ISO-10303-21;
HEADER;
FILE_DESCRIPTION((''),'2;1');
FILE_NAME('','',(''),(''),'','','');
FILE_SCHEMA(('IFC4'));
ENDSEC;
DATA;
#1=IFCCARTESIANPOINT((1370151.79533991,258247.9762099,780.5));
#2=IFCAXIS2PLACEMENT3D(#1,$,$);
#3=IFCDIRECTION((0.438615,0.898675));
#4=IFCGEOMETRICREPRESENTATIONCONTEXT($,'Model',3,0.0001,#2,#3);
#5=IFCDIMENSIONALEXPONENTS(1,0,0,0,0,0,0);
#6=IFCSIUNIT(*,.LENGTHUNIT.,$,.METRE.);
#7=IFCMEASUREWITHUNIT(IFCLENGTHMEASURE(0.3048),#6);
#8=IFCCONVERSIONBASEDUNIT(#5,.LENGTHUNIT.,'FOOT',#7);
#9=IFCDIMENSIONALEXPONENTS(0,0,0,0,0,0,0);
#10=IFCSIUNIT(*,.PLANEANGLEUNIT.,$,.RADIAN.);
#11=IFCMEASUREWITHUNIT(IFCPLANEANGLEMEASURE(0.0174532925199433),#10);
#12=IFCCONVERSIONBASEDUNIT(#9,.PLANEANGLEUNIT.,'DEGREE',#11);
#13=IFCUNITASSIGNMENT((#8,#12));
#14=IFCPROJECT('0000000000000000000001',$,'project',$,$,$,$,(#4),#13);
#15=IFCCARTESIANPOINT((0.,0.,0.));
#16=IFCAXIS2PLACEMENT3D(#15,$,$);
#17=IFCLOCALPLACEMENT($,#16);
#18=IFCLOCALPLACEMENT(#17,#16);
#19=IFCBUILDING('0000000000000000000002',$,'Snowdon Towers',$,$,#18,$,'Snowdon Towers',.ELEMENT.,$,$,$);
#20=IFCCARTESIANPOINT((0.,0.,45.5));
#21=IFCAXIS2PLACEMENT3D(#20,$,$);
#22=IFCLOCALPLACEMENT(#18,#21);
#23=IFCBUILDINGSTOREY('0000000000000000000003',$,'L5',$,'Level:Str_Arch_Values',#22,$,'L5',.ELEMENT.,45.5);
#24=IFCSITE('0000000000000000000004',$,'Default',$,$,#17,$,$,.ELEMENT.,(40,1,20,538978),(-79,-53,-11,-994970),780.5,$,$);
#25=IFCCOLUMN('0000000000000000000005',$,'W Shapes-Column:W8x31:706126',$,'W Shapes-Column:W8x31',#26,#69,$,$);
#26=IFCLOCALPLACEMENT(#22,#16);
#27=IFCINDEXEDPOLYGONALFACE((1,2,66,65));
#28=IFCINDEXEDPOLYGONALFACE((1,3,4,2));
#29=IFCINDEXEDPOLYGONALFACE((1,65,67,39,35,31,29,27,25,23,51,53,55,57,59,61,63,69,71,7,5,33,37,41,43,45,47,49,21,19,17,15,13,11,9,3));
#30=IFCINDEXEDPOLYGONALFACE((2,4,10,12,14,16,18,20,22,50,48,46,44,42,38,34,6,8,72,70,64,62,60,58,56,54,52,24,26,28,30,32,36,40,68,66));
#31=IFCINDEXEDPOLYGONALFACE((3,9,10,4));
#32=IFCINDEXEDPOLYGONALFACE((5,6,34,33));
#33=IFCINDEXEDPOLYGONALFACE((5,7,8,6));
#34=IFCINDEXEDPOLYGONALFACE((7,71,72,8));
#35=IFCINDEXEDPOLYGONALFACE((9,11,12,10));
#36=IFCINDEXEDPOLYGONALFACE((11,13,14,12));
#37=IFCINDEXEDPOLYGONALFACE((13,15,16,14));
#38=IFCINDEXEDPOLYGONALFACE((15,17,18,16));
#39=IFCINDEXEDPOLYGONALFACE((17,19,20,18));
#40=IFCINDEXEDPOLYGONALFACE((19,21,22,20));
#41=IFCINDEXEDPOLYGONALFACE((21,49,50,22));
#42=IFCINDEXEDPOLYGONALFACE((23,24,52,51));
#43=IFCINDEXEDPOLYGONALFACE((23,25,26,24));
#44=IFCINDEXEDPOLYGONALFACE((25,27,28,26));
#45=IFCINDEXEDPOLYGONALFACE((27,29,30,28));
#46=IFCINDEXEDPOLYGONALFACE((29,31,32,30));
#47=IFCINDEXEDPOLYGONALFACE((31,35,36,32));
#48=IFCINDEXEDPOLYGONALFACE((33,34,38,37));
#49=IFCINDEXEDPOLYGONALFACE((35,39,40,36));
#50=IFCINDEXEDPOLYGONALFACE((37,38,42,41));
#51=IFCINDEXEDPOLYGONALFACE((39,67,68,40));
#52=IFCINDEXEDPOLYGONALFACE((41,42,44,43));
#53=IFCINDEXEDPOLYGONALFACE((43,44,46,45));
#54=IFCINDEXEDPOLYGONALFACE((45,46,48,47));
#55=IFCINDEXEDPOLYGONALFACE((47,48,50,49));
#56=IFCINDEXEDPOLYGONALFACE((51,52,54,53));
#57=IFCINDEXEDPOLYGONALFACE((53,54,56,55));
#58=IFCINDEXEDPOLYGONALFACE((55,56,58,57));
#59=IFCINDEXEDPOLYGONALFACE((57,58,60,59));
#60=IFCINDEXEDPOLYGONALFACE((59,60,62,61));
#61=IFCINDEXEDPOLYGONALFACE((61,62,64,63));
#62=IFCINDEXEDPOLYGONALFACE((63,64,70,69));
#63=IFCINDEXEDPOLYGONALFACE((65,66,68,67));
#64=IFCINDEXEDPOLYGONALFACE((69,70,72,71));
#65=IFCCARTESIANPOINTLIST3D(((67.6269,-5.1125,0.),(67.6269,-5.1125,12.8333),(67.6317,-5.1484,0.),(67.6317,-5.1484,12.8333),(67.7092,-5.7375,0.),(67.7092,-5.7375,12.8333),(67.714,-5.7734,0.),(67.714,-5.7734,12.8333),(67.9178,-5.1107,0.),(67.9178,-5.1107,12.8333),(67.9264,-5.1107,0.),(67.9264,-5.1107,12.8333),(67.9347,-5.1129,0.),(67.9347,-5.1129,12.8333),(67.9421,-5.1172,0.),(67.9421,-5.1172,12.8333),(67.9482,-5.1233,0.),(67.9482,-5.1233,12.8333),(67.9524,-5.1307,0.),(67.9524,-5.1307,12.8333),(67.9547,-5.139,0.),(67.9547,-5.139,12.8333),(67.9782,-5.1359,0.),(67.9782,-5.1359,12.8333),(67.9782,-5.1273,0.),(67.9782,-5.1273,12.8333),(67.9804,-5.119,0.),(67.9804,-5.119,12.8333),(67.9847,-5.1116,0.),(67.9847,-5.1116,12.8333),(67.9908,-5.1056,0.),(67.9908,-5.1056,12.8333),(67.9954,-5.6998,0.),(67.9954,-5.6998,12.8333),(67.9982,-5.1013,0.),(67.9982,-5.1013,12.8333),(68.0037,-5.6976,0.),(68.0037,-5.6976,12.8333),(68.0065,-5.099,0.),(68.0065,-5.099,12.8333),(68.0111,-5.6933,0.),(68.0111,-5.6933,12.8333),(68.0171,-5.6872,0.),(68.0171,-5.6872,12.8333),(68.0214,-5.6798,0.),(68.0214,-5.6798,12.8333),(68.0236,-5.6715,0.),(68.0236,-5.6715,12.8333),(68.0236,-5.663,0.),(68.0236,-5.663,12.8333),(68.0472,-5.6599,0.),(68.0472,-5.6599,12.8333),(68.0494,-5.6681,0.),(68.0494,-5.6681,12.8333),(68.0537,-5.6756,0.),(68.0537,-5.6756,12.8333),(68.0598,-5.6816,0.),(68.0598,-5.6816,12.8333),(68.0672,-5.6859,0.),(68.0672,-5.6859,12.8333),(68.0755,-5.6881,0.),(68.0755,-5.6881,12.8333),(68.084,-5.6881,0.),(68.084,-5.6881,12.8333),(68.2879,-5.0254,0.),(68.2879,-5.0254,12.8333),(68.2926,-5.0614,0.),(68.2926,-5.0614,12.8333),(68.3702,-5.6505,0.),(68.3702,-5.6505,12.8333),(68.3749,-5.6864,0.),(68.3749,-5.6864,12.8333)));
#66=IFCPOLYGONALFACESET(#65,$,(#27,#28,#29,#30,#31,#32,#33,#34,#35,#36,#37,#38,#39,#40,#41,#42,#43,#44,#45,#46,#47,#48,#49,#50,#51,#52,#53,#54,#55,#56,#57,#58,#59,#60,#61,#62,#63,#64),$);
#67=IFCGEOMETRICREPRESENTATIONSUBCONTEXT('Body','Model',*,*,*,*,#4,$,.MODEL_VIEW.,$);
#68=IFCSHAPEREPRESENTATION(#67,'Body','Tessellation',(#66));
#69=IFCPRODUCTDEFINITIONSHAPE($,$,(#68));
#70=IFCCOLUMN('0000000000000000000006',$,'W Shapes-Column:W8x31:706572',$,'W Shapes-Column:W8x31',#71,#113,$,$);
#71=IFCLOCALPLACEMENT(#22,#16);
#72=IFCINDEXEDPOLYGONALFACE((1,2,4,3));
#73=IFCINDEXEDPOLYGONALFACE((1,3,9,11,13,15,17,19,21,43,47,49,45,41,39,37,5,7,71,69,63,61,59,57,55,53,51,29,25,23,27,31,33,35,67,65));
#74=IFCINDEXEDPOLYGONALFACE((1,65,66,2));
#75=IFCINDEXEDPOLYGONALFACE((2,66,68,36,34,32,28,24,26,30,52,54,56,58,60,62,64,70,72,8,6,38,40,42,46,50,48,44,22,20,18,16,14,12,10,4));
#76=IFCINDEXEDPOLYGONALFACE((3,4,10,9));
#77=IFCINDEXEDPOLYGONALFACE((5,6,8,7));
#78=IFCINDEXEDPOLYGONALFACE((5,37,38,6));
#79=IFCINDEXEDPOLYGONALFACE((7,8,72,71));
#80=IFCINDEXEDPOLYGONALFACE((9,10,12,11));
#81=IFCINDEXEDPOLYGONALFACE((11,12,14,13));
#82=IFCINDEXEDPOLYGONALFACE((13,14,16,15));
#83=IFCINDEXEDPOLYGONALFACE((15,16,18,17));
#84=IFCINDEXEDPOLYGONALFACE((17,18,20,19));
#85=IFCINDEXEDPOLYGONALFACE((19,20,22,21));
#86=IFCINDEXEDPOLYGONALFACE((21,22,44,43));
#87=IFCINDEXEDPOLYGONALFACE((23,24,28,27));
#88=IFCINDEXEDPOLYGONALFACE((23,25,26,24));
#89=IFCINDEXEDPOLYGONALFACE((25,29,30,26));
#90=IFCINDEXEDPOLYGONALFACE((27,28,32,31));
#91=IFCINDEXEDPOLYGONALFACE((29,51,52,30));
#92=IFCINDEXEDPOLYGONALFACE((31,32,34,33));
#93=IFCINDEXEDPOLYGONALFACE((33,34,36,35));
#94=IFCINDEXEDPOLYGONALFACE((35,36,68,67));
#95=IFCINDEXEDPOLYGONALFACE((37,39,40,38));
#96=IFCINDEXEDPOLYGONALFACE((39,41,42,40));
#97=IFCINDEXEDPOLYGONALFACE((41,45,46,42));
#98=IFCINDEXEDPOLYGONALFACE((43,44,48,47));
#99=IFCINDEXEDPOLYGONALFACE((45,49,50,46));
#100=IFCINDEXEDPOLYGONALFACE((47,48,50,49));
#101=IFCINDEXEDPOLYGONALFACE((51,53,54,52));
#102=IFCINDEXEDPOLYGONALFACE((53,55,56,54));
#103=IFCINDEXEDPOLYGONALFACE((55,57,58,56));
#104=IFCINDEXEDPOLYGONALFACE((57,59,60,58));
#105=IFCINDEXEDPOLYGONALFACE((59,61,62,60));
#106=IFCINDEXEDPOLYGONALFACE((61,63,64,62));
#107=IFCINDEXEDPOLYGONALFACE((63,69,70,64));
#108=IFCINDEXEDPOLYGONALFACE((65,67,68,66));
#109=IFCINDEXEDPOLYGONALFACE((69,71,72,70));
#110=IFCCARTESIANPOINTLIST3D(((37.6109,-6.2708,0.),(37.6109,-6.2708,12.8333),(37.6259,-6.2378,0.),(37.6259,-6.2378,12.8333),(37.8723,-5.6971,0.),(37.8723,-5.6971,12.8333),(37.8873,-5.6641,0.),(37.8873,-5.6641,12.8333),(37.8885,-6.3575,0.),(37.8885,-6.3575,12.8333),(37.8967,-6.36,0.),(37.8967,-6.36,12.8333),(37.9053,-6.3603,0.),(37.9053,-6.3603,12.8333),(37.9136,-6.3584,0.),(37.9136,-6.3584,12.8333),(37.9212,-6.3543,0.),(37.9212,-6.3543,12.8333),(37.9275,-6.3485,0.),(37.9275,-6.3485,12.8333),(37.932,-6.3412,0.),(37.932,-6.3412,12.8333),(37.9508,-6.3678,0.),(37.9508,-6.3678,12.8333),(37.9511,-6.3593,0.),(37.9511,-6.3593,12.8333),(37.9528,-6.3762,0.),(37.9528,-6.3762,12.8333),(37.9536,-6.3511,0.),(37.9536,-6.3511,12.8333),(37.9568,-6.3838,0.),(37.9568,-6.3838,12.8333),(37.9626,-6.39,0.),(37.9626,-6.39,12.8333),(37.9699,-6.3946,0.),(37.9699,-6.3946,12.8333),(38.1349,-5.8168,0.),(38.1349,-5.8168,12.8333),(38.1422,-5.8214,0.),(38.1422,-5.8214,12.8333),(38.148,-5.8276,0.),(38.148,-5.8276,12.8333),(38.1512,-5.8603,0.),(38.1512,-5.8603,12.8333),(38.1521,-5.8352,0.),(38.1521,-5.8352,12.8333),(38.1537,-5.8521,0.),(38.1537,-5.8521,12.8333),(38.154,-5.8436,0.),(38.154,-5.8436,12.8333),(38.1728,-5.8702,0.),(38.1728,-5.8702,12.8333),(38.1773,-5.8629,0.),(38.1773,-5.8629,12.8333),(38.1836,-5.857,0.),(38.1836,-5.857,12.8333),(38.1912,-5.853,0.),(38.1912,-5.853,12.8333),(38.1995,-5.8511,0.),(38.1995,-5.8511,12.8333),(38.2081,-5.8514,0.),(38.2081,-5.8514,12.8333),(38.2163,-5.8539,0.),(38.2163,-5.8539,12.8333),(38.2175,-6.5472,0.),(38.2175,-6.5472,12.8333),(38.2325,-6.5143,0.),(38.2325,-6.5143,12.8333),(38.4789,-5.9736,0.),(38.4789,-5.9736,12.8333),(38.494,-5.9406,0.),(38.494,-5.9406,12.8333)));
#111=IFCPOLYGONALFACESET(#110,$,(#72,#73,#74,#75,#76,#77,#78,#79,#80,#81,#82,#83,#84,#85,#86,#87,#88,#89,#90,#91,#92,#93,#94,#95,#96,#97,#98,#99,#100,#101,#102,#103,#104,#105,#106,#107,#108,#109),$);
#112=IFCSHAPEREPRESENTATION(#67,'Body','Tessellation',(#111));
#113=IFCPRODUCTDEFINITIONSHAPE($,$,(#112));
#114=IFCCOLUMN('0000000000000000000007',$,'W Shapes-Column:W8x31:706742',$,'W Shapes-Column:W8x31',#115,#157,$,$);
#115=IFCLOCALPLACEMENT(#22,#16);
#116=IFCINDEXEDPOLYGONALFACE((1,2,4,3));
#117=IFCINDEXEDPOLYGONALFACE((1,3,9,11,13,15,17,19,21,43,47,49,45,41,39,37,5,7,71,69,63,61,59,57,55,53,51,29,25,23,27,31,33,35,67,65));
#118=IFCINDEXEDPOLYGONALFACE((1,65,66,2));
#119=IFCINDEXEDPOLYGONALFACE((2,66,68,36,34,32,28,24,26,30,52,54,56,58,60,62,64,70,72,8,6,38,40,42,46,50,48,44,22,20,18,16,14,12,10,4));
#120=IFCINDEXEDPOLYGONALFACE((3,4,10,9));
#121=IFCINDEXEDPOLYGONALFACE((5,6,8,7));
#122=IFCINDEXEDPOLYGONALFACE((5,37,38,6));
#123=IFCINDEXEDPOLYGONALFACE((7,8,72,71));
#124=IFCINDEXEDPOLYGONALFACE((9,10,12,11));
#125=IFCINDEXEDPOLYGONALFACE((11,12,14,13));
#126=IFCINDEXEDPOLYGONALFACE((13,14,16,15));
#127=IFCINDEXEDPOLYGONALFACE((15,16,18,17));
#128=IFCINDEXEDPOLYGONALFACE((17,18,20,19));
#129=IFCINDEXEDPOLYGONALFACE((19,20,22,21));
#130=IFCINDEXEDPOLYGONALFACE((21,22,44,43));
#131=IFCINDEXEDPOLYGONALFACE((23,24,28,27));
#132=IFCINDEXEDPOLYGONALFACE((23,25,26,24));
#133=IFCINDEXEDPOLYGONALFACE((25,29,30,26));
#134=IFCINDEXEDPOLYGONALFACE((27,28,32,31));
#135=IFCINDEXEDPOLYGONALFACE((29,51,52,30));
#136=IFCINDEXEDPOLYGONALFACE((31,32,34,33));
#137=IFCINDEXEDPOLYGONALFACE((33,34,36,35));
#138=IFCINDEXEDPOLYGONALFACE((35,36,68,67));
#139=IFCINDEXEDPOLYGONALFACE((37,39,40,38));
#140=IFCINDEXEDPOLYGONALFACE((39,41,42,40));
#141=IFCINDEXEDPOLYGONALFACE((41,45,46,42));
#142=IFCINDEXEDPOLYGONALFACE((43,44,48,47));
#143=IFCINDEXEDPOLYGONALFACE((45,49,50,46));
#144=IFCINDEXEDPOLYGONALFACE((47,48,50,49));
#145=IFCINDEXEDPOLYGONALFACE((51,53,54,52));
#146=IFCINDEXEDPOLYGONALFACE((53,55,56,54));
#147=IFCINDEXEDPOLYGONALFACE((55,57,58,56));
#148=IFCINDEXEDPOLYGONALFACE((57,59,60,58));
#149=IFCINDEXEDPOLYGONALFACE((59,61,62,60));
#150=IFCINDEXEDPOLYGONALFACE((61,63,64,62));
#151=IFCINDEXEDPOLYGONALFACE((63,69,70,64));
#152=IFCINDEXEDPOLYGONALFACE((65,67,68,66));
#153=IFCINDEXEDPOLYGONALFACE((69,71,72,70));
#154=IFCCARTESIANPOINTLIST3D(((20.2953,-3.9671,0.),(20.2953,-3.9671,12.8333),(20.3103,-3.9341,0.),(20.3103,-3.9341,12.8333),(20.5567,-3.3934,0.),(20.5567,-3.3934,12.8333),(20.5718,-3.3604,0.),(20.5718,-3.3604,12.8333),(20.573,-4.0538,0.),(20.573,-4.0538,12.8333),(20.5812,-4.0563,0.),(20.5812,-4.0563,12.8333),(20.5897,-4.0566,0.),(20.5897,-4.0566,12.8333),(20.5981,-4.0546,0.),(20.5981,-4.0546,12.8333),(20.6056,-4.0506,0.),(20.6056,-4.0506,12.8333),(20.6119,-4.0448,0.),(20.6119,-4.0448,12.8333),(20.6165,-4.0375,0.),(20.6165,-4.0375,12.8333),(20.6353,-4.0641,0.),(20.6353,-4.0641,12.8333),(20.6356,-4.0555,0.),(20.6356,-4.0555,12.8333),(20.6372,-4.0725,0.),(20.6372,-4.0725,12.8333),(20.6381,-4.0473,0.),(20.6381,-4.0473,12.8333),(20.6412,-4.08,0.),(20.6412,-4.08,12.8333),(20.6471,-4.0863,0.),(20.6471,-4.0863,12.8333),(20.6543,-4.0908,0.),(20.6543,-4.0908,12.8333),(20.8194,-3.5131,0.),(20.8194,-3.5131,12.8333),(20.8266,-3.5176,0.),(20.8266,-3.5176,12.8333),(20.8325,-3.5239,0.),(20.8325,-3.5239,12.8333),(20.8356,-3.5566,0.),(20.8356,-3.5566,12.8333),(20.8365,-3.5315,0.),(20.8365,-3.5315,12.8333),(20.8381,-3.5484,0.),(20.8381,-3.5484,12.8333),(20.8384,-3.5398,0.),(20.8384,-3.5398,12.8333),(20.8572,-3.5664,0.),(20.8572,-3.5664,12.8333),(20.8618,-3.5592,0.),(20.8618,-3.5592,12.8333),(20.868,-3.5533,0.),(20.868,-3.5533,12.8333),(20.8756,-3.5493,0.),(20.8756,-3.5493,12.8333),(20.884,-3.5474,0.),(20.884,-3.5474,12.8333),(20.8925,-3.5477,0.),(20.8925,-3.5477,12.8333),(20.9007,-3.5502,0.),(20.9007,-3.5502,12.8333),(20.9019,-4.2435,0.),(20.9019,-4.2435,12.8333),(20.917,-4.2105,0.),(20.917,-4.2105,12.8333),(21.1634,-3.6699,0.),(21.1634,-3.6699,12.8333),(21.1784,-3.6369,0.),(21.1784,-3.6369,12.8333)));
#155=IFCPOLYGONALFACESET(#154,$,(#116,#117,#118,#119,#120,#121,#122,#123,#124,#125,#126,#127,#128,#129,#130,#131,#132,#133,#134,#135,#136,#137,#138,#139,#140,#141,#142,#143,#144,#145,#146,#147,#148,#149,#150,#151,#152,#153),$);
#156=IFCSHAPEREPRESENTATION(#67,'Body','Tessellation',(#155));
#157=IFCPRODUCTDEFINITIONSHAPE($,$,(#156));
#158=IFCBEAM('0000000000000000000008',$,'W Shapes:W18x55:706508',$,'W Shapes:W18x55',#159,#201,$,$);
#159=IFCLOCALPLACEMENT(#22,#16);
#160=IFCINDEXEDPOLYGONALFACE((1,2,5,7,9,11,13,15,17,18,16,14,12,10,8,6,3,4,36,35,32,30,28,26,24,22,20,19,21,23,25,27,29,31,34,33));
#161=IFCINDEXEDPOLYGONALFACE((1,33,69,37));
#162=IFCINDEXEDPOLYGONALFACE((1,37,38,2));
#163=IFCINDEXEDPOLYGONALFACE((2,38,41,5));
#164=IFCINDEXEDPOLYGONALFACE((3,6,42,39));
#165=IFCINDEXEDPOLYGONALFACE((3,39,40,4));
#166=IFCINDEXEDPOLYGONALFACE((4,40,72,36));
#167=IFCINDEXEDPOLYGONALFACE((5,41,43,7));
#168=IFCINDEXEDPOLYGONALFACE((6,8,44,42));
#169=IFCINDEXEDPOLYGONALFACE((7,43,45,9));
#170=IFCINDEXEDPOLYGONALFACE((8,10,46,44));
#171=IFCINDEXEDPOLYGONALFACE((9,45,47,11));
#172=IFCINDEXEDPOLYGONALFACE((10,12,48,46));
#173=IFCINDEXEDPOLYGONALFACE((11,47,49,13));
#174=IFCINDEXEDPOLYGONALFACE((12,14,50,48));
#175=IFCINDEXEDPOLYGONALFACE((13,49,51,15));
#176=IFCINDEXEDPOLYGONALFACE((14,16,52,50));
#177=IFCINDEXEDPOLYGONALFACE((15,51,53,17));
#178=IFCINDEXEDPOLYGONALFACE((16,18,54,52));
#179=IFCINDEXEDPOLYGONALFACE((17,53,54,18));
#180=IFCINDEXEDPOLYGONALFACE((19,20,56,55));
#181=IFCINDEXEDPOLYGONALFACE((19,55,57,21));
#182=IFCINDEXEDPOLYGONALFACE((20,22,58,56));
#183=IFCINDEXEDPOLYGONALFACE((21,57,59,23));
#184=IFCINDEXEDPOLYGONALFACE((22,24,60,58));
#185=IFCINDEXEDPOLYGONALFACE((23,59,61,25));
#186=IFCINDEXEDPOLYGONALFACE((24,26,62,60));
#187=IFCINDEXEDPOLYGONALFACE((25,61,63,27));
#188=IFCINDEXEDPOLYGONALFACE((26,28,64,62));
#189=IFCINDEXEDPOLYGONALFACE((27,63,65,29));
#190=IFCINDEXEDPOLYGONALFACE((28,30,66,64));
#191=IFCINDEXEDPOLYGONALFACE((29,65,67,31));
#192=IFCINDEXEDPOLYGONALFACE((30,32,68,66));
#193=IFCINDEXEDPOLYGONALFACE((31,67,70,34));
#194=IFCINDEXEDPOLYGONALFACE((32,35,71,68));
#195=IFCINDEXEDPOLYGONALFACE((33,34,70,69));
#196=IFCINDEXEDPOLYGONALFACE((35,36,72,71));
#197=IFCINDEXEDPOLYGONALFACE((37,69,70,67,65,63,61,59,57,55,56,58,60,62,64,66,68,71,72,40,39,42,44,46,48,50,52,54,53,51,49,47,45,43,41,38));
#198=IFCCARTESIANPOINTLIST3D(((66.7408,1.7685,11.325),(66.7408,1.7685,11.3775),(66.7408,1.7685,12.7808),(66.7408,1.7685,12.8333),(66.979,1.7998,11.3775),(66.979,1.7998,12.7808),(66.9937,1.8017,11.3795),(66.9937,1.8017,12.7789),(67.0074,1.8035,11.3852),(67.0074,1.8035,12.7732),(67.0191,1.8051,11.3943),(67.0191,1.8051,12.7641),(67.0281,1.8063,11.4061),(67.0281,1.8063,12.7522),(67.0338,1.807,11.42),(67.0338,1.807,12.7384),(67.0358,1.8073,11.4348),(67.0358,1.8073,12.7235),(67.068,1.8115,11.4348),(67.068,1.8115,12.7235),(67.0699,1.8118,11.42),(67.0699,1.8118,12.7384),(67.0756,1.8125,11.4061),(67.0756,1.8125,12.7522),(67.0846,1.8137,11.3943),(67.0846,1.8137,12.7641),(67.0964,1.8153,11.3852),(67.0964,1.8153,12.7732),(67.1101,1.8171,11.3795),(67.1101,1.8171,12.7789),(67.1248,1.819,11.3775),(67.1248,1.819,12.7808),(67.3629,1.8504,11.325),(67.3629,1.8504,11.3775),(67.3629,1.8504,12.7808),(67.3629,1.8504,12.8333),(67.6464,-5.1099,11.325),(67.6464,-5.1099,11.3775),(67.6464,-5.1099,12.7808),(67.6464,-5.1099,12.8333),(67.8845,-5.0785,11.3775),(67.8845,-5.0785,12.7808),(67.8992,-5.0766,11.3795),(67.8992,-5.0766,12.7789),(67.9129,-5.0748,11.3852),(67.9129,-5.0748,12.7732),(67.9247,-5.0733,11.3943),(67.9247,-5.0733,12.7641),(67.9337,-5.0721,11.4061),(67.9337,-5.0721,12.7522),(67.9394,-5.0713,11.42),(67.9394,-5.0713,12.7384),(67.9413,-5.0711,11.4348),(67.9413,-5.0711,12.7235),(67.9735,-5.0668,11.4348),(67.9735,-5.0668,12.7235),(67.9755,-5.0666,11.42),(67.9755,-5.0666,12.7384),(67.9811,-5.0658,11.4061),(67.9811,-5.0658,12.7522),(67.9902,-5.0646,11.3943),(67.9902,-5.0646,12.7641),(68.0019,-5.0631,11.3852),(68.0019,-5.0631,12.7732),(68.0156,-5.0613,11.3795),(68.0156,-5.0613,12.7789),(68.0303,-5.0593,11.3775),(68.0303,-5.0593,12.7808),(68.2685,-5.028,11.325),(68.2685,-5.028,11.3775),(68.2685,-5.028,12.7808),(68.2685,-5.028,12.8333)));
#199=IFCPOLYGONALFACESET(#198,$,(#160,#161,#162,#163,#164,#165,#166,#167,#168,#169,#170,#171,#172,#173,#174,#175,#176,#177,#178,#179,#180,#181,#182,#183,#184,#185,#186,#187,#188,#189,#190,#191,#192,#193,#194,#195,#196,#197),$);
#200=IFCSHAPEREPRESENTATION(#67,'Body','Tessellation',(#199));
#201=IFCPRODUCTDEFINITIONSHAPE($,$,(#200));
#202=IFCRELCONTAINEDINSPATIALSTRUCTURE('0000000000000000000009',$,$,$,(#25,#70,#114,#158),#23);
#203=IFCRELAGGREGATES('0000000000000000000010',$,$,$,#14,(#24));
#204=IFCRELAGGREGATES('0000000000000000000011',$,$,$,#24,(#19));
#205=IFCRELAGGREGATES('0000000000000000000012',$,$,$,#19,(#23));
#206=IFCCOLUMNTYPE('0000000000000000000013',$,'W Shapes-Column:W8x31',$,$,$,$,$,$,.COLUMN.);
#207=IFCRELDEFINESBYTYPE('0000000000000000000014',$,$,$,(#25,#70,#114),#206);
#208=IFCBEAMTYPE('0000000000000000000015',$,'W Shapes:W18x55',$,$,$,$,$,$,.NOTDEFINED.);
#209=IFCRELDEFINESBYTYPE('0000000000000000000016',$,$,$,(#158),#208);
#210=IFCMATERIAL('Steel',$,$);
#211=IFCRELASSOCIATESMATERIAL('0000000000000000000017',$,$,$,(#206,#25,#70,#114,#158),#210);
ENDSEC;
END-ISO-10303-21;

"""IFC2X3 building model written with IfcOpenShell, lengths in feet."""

from ifc_helpers import new_model, entity, si_unit, converted_unit, direction, frame, frame_2d, origin, place, context, subcontext, project, spatial, i_section, extrude, source, transform, mapped, material, type_object, type_shapes, element, save


model = new_model("IFC2X3")

# Units and contexts
model_context = context("Model", 3, precision=0.0001, world=frame((1370151.79533991, 258247.9762099, 780.5)), true_north=direction((0.438615, 0.898675)))
body_context = subcontext(model_context, "Body", "Model", "MODEL_VIEW")
ifc_project = project(units=[converted_unit("LENGTHUNIT", "FOOT", entity("IfcLengthMeasure", 0.3048), si_unit("LENGTHUNIT", "METRE"), dimensions=[1, 0, 0, 0, 0, 0, 0]), converted_unit("PLANEANGLEUNIT", "DEGREE", entity("IfcPlaneAngleMeasure", 0.0174532925199433), si_unit("PLANEANGLEUNIT", "RADIAN"), dimensions=[0, 0, 0, 0, 0, 0, 0])], contexts=[model_context])

# Site, building, storey
site_placement = place(None, origin())
site = spatial("IfcSite", under=ifc_project, at=site_placement, Name="Default", CompositionType="ELEMENT", RefLatitude=(40, 1, 20, 538978), RefLongitude=(-79, -53, -11, -994970), RefElevation=780.5)
building_placement = place(site_placement, origin())
building = spatial("IfcBuilding", under=site, at=building_placement, Name="Snowdon Towers", LongName="Snowdon Towers", CompositionType="ELEMENT")
storey_placement = place(building_placement, frame((0.0, 0.0, 45.5)))
storey = spatial("IfcBuildingStorey", under=building, at=storey_placement, Name="L5", ObjectType="Level:Str_Arch_Values", LongName="L5", CompositionType="ELEMENT", Elevation=45.5)

# Columns
ifc_material = material(Name="Steel")
column_type = type_object("IfcColumnType", Name="W Shapes-Column:W8x31", PredefinedType="COLUMN", material=ifc_material)
shared_shape = source(origin(), body_context, "Body", "SweptSolid", [
    extrude(i_section(OverallWidth=0.6667, OverallDepth=0.6667, WebThickness=0.0238, FlangeThickness=0.0362, FilletRadius=0.0328, at=frame_2d((0.0, 0.0), x_axis=(1.0, 0.0))), frame((0.0, 0.0, 45.5), z_axis=(0.0, 0.0, 1.0), x_axis=(-1.0, 0.0, 0.0)), (0.0, 0.0, 1.0), 12.8333),
])
type_shapes(column_type, [shared_shape])
for number, where, z_axis, x_axis, name in (
    (1, (68.0009, -5.3994, -45.5), (0.0, 0.0, 1.0), (0.991445, 0.130526, 0.0), "W Shapes-Column:W8x31:706126"),
    (2, (38.0524, -6.1057, -45.5), (0.0, 0.0, 1.0), (0.909961, -0.414693, 0.0), "W Shapes-Column:W8x31:706572"),
    (3, (20.7368, -3.802, -45.5), (0.0, 0.0, 1.0), (0.909961, -0.414693, 0.0), "W Shapes-Column:W8x31:706742"),
):
    element("IfcColumn", number, at=place(storey_placement, frame(where, z_axis=z_axis, x_axis=x_axis)), inside=storey, type_object=column_type, material=ifc_material, Name=name, ObjectType="W Shapes-Column:W8x31", context=body_context, shape_type="MappedRepresentation", body=[
        mapped(shared_shape, transform((0.0, 0.0, 0.0), scale=1.0)),
    ])

# Beam
beam_type_1 = type_object("IfcBeamType", Name="W Shapes:W18x55", PredefinedType="NOTDEFINED")
beam_1_placement = place(storey_placement, frame((66.961, 2.5, 12.8333), z_axis=(0.0, 0.0, 1.0), x_axis=(0.130526, -0.991445, 0.0)))
element("IfcBeam", 4, at=beam_1_placement, inside=storey, type_object=beam_type_1, material=ifc_material, Name="W Shapes:W18x55:706508", ObjectType="W Shapes:W18x55", context=body_context, shape_type="SweptSolid", body=[
    extrude(i_section(OverallWidth=0.6275, OverallDepth=1.5083, WebThickness=0.0325, FlangeThickness=0.0525, FilletRadius=0.0573, at=frame_2d((0.0, 0.0), x_axis=(0.0, 1.0))), frame((0.6966, 0.0, -0.7542), z_axis=(1.0, 0.0, 0.0), x_axis=(0.0, 0.0, -1.0)), (0.0, 0.0, 1.0), 6.9377),
])

save(model, "model.ifc")
